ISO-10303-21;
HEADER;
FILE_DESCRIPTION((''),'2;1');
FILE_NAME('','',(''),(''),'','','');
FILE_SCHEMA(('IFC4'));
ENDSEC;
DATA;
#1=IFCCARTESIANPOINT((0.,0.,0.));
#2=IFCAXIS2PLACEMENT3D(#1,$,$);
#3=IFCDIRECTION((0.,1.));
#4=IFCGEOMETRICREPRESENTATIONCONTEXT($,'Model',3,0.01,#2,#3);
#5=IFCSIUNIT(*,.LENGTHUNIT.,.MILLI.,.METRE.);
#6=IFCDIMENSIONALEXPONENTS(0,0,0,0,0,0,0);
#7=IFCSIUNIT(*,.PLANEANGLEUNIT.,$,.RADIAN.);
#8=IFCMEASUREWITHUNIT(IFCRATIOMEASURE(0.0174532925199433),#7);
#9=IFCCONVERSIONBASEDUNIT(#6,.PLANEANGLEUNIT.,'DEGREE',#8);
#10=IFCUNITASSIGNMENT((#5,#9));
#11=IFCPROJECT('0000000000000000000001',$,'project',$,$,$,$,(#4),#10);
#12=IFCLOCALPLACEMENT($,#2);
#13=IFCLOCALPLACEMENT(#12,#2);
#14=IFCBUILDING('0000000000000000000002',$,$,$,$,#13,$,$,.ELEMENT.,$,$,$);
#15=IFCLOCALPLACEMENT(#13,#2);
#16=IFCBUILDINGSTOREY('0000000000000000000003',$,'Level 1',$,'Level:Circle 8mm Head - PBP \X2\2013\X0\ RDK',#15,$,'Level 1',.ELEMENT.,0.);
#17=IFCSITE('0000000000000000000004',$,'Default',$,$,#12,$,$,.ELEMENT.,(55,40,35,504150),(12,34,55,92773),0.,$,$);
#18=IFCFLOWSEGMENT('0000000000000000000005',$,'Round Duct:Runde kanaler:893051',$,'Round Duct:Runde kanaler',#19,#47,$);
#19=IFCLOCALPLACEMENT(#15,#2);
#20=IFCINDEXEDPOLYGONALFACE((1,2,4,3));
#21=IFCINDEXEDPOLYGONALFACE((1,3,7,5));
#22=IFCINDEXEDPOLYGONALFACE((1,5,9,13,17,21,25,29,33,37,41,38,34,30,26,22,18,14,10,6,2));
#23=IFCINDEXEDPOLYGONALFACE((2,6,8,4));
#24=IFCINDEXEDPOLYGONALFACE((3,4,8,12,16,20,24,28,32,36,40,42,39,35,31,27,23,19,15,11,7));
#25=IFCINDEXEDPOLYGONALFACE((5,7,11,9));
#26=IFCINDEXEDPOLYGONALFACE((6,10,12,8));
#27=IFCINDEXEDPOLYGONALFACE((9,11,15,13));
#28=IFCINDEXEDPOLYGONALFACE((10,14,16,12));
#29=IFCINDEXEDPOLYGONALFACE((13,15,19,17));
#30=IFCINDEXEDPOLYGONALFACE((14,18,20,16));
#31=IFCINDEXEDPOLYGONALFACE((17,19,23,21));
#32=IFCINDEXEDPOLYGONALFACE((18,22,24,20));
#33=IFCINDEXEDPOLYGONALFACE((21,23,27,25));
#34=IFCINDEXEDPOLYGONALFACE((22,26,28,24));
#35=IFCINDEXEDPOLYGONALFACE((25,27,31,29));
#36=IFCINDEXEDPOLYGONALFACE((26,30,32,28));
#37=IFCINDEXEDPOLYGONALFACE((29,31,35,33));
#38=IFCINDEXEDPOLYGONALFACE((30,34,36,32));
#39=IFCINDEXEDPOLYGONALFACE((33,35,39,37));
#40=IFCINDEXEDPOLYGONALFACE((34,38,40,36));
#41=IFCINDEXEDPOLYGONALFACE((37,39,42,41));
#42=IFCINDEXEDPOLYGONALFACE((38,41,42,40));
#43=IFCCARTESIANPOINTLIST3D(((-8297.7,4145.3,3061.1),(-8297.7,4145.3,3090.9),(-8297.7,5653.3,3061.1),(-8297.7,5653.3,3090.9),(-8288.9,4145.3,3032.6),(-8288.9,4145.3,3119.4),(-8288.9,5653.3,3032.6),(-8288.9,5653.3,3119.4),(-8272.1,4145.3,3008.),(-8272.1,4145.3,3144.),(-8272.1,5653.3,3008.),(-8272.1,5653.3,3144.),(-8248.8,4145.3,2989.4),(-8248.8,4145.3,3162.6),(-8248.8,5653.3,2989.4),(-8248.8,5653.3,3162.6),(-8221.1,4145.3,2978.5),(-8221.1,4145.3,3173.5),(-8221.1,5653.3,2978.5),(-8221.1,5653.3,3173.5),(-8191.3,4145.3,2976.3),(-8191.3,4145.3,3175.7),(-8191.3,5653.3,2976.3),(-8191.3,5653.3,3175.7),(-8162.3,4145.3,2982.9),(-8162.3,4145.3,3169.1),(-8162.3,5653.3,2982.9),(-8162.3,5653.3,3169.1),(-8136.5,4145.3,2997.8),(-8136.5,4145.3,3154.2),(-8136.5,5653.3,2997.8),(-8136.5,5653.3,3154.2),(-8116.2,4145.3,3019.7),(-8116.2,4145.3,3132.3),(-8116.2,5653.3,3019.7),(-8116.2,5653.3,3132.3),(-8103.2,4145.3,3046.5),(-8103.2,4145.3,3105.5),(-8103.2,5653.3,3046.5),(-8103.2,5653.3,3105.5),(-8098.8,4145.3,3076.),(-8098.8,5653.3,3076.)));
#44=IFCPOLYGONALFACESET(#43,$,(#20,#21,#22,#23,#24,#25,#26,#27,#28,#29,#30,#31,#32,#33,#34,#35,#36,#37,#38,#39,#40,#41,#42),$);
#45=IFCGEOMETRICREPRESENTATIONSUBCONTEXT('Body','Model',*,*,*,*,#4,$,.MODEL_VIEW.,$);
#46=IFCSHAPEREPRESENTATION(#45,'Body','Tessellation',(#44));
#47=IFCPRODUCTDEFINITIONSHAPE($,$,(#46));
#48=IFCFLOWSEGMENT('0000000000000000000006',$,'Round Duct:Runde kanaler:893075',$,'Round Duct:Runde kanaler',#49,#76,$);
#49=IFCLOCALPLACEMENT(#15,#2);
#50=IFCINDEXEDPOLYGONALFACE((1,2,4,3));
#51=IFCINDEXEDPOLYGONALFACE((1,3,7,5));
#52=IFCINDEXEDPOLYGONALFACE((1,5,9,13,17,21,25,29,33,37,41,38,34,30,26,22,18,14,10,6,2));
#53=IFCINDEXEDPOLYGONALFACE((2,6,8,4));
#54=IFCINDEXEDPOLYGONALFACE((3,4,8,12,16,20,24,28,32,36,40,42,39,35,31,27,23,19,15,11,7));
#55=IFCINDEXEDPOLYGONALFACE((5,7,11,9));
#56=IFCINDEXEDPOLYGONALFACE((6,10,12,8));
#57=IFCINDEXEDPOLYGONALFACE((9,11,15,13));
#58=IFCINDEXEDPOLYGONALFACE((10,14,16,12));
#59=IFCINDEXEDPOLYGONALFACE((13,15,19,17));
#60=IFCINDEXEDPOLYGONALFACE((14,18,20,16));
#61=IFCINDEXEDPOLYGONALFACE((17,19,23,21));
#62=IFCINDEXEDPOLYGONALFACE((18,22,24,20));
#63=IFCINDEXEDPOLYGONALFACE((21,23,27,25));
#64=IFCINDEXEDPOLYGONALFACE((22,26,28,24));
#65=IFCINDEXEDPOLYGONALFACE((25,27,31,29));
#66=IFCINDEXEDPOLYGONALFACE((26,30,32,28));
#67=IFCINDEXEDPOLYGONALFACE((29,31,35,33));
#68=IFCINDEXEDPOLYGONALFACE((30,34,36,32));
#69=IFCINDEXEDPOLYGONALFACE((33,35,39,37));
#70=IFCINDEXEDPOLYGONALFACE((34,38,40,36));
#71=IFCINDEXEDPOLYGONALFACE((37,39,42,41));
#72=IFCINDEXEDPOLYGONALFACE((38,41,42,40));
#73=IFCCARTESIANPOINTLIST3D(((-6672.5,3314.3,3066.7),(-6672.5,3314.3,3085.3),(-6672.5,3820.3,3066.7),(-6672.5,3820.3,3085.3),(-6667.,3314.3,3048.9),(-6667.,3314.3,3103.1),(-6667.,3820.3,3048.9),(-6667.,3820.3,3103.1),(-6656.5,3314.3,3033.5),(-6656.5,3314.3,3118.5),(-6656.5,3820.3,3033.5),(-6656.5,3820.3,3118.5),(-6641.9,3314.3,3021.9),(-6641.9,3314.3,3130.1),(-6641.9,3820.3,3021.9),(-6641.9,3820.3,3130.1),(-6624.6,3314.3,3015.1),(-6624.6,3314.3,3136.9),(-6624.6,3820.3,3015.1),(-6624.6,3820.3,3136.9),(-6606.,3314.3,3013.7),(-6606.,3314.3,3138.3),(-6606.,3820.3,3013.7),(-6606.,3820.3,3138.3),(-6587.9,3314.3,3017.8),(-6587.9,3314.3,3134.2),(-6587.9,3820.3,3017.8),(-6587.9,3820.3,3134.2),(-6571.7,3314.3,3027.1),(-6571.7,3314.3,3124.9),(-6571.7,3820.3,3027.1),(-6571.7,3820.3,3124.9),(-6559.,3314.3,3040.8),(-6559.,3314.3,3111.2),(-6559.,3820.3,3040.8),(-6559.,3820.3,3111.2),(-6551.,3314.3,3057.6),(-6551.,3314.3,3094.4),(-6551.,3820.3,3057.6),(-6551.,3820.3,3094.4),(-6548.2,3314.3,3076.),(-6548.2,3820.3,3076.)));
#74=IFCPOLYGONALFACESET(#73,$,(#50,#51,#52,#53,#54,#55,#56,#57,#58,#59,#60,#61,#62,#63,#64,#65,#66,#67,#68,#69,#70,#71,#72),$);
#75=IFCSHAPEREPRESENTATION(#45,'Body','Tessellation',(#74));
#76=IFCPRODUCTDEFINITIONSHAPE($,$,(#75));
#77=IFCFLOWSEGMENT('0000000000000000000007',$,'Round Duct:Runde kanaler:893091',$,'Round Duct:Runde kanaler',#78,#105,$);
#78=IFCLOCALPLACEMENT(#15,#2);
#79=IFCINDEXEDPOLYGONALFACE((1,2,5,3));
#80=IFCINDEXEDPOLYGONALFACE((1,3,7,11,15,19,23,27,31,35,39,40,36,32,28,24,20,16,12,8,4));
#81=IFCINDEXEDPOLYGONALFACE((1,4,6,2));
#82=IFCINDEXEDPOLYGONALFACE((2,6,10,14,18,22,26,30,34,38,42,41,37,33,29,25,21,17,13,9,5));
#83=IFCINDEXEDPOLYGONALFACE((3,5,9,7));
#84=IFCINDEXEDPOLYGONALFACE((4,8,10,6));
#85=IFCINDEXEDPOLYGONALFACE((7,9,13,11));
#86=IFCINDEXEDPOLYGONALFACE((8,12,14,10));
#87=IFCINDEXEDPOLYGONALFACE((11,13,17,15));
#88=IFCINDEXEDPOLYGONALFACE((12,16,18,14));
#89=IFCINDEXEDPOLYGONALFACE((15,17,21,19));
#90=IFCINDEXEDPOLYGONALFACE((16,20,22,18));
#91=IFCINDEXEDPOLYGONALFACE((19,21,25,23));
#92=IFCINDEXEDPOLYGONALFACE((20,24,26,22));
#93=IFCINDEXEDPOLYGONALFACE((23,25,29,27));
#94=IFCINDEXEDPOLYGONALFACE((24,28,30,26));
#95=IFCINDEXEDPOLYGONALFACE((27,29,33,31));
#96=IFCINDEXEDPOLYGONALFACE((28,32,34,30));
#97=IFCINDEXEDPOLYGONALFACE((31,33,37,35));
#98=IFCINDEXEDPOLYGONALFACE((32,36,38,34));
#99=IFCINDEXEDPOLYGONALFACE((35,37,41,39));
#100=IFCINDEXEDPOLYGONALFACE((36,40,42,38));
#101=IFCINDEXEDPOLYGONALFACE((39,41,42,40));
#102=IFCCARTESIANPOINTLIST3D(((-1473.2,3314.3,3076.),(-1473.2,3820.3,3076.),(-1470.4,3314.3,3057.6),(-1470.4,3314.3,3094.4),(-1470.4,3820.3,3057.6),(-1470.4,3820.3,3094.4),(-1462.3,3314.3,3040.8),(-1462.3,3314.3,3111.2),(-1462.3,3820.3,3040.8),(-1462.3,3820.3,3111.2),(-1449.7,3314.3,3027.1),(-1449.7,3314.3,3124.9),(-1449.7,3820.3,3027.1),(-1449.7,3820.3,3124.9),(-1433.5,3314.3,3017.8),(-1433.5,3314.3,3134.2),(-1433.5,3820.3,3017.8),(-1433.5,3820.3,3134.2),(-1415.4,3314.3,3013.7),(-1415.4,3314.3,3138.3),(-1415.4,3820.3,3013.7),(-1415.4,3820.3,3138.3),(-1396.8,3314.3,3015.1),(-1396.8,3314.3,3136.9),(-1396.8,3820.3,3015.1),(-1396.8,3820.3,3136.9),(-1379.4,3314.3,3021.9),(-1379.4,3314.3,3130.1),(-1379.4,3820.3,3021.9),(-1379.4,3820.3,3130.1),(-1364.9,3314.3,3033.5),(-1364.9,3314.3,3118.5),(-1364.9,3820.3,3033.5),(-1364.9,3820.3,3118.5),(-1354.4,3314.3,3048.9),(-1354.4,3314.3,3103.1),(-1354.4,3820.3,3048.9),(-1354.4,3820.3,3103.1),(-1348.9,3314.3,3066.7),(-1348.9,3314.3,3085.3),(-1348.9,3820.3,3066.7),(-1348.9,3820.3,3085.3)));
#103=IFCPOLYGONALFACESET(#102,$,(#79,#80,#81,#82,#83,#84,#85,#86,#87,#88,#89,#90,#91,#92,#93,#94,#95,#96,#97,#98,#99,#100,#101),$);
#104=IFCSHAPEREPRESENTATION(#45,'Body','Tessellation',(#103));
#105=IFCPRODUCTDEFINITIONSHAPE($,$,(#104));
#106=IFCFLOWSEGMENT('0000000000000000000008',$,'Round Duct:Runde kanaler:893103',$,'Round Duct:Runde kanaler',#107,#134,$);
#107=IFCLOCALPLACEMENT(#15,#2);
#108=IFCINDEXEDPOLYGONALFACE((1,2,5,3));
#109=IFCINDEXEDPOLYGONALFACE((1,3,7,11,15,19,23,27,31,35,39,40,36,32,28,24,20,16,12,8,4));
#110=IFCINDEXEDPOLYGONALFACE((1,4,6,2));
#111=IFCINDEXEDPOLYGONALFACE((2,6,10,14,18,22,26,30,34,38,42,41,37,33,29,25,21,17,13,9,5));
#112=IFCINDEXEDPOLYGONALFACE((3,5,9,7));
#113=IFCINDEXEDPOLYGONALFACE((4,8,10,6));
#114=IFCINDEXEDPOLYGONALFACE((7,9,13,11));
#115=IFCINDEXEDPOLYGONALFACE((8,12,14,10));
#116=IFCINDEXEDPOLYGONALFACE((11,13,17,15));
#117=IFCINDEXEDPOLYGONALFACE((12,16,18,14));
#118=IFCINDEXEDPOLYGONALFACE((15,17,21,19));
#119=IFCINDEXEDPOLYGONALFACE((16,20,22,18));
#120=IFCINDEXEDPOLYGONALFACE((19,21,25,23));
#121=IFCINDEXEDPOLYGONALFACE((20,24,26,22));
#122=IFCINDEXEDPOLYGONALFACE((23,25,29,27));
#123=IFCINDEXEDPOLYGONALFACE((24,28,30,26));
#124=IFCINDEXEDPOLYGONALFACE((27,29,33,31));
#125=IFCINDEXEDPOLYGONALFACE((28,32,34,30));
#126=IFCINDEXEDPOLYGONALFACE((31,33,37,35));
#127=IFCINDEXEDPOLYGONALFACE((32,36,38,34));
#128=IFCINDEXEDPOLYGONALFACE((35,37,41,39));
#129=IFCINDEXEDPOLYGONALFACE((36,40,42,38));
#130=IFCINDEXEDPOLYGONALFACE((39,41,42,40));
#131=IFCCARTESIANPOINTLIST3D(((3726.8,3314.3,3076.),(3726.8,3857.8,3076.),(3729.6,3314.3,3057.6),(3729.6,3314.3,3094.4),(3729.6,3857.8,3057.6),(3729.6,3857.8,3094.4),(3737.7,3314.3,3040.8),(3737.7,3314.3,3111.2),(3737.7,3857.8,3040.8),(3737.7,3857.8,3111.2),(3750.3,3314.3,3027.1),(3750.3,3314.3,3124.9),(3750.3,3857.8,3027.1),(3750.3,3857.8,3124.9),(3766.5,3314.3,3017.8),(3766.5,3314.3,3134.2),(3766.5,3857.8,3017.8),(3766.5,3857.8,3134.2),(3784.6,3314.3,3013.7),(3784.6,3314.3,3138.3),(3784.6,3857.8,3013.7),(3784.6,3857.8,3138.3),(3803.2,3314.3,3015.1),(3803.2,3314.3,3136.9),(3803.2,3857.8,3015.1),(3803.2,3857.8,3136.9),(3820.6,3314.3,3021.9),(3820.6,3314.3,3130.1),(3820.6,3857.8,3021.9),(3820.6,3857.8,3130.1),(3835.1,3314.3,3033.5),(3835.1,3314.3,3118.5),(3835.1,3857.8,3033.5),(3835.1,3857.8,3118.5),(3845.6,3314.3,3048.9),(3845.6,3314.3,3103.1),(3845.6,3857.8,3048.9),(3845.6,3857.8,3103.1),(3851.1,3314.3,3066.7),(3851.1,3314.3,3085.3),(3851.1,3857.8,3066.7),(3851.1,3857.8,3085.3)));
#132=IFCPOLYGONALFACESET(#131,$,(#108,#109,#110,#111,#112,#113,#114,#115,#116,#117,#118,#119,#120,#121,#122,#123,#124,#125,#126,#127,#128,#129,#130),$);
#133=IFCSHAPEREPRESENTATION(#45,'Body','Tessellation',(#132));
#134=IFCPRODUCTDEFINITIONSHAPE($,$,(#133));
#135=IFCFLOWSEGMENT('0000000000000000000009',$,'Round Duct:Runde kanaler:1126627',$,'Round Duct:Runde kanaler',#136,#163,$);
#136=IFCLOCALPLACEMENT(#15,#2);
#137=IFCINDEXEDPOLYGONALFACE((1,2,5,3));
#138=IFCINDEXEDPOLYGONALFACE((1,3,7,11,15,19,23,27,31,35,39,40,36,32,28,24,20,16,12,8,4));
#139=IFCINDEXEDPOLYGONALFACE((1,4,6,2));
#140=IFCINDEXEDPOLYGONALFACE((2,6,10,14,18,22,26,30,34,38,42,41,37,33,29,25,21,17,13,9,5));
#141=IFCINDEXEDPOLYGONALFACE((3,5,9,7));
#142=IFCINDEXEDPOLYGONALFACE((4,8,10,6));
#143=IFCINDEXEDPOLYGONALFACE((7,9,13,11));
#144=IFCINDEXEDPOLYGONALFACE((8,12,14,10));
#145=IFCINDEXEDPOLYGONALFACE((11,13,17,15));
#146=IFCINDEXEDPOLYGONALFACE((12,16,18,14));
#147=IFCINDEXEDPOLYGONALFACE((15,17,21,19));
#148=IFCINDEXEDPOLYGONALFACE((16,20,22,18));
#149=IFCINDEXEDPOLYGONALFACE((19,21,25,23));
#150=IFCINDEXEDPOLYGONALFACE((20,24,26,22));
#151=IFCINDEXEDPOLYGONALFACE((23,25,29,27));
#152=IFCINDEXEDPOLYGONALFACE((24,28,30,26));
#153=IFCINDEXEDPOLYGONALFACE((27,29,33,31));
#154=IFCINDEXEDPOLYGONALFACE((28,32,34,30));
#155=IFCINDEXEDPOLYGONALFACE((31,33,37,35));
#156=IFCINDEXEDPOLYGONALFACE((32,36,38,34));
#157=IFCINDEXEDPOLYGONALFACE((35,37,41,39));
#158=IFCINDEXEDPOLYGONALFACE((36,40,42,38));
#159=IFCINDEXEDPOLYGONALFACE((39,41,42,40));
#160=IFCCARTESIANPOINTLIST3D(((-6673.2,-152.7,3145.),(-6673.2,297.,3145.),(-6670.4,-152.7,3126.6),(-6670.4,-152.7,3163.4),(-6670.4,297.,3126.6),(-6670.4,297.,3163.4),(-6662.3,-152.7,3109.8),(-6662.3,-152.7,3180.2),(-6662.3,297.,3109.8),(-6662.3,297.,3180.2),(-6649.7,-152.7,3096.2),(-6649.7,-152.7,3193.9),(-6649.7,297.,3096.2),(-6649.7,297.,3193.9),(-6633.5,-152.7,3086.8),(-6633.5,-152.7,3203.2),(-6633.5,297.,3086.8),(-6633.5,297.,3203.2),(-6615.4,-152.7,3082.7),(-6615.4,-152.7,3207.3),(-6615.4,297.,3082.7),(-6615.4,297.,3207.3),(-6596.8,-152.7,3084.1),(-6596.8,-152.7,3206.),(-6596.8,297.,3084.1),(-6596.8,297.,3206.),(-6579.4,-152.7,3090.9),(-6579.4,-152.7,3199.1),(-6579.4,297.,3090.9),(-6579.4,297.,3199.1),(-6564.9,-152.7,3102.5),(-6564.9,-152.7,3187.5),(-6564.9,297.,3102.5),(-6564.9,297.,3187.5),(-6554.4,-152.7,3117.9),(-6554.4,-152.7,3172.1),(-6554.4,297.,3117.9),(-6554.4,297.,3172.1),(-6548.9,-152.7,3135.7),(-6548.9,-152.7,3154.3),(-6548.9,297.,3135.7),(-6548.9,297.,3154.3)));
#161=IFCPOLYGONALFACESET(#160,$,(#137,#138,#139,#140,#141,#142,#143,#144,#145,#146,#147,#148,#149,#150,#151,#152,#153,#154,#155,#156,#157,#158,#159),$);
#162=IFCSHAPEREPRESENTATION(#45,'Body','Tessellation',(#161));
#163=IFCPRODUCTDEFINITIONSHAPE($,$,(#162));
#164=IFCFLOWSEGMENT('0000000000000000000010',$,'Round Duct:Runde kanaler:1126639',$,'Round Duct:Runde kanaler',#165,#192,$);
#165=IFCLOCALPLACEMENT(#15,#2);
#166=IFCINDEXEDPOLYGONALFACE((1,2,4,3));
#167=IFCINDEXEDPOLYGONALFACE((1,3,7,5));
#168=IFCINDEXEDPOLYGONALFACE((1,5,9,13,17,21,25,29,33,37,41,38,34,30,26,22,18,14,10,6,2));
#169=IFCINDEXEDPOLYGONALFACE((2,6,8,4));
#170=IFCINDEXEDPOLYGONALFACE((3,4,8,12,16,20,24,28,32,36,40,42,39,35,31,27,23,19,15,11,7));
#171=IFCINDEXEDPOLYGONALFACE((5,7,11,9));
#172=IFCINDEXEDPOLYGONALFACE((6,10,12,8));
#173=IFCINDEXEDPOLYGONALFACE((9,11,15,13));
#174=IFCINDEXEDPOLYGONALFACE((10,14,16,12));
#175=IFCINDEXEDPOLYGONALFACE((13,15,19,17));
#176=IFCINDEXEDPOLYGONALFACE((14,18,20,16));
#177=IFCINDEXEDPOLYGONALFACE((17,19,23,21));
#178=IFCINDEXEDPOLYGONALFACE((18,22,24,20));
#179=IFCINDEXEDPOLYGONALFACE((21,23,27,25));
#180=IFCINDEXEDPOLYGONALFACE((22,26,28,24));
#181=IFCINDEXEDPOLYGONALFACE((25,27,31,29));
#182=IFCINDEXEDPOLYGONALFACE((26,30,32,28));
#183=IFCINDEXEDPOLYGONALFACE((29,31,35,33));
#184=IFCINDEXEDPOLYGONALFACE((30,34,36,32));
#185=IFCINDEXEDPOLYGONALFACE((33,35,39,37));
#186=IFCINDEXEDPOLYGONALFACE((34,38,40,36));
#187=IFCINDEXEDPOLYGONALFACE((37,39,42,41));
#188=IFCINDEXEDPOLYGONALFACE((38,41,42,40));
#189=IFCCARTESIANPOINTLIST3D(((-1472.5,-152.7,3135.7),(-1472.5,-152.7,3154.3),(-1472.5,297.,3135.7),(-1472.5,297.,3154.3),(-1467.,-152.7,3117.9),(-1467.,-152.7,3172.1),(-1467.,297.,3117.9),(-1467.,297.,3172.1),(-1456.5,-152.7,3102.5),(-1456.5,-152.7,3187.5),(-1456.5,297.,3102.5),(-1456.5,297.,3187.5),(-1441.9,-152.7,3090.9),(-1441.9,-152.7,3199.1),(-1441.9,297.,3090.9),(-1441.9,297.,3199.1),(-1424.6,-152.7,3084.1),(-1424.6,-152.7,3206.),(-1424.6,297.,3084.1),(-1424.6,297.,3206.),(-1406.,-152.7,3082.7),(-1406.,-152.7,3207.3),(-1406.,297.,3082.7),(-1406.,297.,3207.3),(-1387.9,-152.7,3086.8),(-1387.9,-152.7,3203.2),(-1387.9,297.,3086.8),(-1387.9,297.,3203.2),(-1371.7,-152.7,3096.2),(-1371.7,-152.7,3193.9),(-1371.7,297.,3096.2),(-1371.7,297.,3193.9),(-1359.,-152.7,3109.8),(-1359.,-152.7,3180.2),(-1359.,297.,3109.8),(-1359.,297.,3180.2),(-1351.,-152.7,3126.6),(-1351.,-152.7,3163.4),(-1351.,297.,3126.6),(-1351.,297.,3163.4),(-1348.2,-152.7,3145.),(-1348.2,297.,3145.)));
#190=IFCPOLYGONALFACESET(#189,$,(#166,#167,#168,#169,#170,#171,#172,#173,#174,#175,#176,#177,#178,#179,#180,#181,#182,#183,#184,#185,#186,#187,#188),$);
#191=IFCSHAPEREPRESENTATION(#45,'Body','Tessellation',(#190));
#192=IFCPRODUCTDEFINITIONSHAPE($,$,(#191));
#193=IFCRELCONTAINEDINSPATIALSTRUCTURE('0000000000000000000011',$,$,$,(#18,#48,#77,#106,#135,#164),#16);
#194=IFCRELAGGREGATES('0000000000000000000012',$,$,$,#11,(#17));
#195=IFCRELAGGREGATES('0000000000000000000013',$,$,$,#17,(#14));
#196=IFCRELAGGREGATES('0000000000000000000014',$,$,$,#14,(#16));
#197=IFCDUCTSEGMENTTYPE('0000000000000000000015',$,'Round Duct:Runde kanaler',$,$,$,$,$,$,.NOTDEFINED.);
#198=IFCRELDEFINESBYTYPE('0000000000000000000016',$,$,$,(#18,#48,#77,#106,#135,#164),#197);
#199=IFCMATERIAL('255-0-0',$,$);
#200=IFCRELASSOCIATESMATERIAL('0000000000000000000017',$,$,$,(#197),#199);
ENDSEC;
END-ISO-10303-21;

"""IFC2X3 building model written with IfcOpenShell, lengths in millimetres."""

from ifc_helpers import new_model, entity, si_unit, converted_unit, direction, frame, frame_2d, origin, origin_2d_with_axis, place, context, subcontext, project, spatial, circle, extrude, material, type_object, element, save


model = new_model("IFC2X3")

# Units and contexts
model_context = context("Model", 3, precision=0.01, world=origin(), true_north=direction((0.0, 1.0)))
body_context = subcontext(model_context, "Body", "Model", "MODEL_VIEW")
ifc_project = project(units=[si_unit("LENGTHUNIT", "METRE", prefix="MILLI"), converted_unit("PLANEANGLEUNIT", "DEGREE", entity("IfcRatioMeasure", 0.0174532925199433), si_unit("PLANEANGLEUNIT", "RADIAN"), dimensions=[0, 0, 0, 0, 0, 0, 0])], contexts=[model_context])

# Site, building, storey
site_placement = place(None, origin())
site = spatial("IfcSite", under=ifc_project, at=site_placement, Name="Default", CompositionType="ELEMENT", RefLatitude=(55, 40, 35, 504150), RefLongitude=(12, 34, 55, 92773), RefElevation=0.0)
building_placement = place(site_placement, origin())
building = spatial("IfcBuilding", under=site, at=building_placement, CompositionType="ELEMENT")
storey_placement = place(building_placement, origin())
storey = spatial("IfcBuildingStorey", under=building, at=storey_placement, Name="Level 1", ObjectType="Level:Circle 8mm Head - PBP – RDK", LongName="Level 1", CompositionType="ELEMENT", Elevation=0.0)

# Flow segments
ifc_material_1 = material(Name="255-0-0")
duct_segment_type = type_object("IfcDuctSegmentType", Name="Round Duct:Runde kanaler", PredefinedType="NOTDEFINED", material=ifc_material_1)
flow_segment_1_placement = place(storey_placement, origin())
element("IfcFlowSegment", 1, at=flow_segment_1_placement, inside=storey, type_object=duct_segment_type, Name="Round Duct:Runde kanaler:893051", ObjectType="Round Duct:Runde kanaler", context=body_context, shape_type="SweptSolid", body=[
    extrude(circle(Radius=100.0, at=origin_2d_with_axis()), frame((-8198.8, 4145.3, 3076.0), z_axis=(0.0, 1.0, 0.0), x_axis=(1.0, 0.0, 0.0)), (0.0, 0.0, 1.0), 1508.0),
])
flow_segment_2_placement = place(storey_placement, origin())
element("IfcFlowSegment", 2, at=flow_segment_2_placement, inside=storey, type_object=duct_segment_type, Name="Round Duct:Runde kanaler:893075", ObjectType="Round Duct:Runde kanaler", context=body_context, shape_type="SweptSolid", body=[
    extrude(circle(Radius=62.5, at=frame_2d((0.0, 0.0), x_axis=(1.0, 0.0))), frame((-6610.7, 3314.3, 3076.0), z_axis=(0.0, 1.0, 0.0), x_axis=(1.0, 0.0, 0.0)), (0.0, 0.0, 1.0), 506.0),
])
flow_segment_3_placement = place(storey_placement, origin())
element("IfcFlowSegment", 3, at=flow_segment_3_placement, inside=storey, type_object=duct_segment_type, Name="Round Duct:Runde kanaler:893091", ObjectType="Round Duct:Runde kanaler", context=body_context, shape_type="SweptSolid", body=[
    extrude(circle(Radius=62.5, at=origin_2d_with_axis()), frame((-1410.7, 3314.3, 3076.0), z_axis=(0.0, 1.0, 0.0), x_axis=(-1.0, 0.0, 0.0)), (0.0, 0.0, 1.0), 506.0),
])
flow_segment_4_placement = place(storey_placement, origin())
element("IfcFlowSegment", 4, at=flow_segment_4_placement, inside=storey, type_object=duct_segment_type, Name="Round Duct:Runde kanaler:893103", ObjectType="Round Duct:Runde kanaler", context=body_context, shape_type="SweptSolid", body=[
    extrude(circle(Radius=62.5, at=frame_2d((0.0, 0.0), x_axis=(1.0, 0.0))), frame((3789.3, 3314.3, 3076.0), z_axis=(0.0, 1.0, 0.0), x_axis=(-1.0, 0.0, 0.0)), (0.0, 0.0, 1.0), 543.5),
])
flow_segment_5_placement = place(storey_placement, origin())
element("IfcFlowSegment", 5, at=flow_segment_5_placement, inside=storey, type_object=duct_segment_type, Name="Round Duct:Runde kanaler:1126627", ObjectType="Round Duct:Runde kanaler", context=body_context, shape_type="SweptSolid", body=[
    extrude(circle(Radius=62.5, at=frame_2d((0.0, 0.0), x_axis=(1.0, 0.0))), frame((-6610.7, -152.7, 3145.0), z_axis=(0.0, 1.0, 0.0), x_axis=(-1.0, 0.0, 0.0)), (0.0, 0.0, 1.0), 449.8),
])
flow_segment_6_placement = place(storey_placement, origin())
element("IfcFlowSegment", 6, at=flow_segment_6_placement, inside=storey, type_object=duct_segment_type, Name="Round Duct:Runde kanaler:1126639", ObjectType="Round Duct:Runde kanaler", context=body_context, shape_type="SweptSolid", body=[
    extrude(circle(Radius=62.5, at=frame_2d((0.0, 0.0), x_axis=(1.0, 0.0))), frame((-1410.7, -152.7, 3145.0), z_axis=(0.0, 1.0, 0.0), x_axis=(1.0, 0.0, 0.0)), (0.0, 0.0, 1.0), 449.8),
])

save(model, "model.ifc")
